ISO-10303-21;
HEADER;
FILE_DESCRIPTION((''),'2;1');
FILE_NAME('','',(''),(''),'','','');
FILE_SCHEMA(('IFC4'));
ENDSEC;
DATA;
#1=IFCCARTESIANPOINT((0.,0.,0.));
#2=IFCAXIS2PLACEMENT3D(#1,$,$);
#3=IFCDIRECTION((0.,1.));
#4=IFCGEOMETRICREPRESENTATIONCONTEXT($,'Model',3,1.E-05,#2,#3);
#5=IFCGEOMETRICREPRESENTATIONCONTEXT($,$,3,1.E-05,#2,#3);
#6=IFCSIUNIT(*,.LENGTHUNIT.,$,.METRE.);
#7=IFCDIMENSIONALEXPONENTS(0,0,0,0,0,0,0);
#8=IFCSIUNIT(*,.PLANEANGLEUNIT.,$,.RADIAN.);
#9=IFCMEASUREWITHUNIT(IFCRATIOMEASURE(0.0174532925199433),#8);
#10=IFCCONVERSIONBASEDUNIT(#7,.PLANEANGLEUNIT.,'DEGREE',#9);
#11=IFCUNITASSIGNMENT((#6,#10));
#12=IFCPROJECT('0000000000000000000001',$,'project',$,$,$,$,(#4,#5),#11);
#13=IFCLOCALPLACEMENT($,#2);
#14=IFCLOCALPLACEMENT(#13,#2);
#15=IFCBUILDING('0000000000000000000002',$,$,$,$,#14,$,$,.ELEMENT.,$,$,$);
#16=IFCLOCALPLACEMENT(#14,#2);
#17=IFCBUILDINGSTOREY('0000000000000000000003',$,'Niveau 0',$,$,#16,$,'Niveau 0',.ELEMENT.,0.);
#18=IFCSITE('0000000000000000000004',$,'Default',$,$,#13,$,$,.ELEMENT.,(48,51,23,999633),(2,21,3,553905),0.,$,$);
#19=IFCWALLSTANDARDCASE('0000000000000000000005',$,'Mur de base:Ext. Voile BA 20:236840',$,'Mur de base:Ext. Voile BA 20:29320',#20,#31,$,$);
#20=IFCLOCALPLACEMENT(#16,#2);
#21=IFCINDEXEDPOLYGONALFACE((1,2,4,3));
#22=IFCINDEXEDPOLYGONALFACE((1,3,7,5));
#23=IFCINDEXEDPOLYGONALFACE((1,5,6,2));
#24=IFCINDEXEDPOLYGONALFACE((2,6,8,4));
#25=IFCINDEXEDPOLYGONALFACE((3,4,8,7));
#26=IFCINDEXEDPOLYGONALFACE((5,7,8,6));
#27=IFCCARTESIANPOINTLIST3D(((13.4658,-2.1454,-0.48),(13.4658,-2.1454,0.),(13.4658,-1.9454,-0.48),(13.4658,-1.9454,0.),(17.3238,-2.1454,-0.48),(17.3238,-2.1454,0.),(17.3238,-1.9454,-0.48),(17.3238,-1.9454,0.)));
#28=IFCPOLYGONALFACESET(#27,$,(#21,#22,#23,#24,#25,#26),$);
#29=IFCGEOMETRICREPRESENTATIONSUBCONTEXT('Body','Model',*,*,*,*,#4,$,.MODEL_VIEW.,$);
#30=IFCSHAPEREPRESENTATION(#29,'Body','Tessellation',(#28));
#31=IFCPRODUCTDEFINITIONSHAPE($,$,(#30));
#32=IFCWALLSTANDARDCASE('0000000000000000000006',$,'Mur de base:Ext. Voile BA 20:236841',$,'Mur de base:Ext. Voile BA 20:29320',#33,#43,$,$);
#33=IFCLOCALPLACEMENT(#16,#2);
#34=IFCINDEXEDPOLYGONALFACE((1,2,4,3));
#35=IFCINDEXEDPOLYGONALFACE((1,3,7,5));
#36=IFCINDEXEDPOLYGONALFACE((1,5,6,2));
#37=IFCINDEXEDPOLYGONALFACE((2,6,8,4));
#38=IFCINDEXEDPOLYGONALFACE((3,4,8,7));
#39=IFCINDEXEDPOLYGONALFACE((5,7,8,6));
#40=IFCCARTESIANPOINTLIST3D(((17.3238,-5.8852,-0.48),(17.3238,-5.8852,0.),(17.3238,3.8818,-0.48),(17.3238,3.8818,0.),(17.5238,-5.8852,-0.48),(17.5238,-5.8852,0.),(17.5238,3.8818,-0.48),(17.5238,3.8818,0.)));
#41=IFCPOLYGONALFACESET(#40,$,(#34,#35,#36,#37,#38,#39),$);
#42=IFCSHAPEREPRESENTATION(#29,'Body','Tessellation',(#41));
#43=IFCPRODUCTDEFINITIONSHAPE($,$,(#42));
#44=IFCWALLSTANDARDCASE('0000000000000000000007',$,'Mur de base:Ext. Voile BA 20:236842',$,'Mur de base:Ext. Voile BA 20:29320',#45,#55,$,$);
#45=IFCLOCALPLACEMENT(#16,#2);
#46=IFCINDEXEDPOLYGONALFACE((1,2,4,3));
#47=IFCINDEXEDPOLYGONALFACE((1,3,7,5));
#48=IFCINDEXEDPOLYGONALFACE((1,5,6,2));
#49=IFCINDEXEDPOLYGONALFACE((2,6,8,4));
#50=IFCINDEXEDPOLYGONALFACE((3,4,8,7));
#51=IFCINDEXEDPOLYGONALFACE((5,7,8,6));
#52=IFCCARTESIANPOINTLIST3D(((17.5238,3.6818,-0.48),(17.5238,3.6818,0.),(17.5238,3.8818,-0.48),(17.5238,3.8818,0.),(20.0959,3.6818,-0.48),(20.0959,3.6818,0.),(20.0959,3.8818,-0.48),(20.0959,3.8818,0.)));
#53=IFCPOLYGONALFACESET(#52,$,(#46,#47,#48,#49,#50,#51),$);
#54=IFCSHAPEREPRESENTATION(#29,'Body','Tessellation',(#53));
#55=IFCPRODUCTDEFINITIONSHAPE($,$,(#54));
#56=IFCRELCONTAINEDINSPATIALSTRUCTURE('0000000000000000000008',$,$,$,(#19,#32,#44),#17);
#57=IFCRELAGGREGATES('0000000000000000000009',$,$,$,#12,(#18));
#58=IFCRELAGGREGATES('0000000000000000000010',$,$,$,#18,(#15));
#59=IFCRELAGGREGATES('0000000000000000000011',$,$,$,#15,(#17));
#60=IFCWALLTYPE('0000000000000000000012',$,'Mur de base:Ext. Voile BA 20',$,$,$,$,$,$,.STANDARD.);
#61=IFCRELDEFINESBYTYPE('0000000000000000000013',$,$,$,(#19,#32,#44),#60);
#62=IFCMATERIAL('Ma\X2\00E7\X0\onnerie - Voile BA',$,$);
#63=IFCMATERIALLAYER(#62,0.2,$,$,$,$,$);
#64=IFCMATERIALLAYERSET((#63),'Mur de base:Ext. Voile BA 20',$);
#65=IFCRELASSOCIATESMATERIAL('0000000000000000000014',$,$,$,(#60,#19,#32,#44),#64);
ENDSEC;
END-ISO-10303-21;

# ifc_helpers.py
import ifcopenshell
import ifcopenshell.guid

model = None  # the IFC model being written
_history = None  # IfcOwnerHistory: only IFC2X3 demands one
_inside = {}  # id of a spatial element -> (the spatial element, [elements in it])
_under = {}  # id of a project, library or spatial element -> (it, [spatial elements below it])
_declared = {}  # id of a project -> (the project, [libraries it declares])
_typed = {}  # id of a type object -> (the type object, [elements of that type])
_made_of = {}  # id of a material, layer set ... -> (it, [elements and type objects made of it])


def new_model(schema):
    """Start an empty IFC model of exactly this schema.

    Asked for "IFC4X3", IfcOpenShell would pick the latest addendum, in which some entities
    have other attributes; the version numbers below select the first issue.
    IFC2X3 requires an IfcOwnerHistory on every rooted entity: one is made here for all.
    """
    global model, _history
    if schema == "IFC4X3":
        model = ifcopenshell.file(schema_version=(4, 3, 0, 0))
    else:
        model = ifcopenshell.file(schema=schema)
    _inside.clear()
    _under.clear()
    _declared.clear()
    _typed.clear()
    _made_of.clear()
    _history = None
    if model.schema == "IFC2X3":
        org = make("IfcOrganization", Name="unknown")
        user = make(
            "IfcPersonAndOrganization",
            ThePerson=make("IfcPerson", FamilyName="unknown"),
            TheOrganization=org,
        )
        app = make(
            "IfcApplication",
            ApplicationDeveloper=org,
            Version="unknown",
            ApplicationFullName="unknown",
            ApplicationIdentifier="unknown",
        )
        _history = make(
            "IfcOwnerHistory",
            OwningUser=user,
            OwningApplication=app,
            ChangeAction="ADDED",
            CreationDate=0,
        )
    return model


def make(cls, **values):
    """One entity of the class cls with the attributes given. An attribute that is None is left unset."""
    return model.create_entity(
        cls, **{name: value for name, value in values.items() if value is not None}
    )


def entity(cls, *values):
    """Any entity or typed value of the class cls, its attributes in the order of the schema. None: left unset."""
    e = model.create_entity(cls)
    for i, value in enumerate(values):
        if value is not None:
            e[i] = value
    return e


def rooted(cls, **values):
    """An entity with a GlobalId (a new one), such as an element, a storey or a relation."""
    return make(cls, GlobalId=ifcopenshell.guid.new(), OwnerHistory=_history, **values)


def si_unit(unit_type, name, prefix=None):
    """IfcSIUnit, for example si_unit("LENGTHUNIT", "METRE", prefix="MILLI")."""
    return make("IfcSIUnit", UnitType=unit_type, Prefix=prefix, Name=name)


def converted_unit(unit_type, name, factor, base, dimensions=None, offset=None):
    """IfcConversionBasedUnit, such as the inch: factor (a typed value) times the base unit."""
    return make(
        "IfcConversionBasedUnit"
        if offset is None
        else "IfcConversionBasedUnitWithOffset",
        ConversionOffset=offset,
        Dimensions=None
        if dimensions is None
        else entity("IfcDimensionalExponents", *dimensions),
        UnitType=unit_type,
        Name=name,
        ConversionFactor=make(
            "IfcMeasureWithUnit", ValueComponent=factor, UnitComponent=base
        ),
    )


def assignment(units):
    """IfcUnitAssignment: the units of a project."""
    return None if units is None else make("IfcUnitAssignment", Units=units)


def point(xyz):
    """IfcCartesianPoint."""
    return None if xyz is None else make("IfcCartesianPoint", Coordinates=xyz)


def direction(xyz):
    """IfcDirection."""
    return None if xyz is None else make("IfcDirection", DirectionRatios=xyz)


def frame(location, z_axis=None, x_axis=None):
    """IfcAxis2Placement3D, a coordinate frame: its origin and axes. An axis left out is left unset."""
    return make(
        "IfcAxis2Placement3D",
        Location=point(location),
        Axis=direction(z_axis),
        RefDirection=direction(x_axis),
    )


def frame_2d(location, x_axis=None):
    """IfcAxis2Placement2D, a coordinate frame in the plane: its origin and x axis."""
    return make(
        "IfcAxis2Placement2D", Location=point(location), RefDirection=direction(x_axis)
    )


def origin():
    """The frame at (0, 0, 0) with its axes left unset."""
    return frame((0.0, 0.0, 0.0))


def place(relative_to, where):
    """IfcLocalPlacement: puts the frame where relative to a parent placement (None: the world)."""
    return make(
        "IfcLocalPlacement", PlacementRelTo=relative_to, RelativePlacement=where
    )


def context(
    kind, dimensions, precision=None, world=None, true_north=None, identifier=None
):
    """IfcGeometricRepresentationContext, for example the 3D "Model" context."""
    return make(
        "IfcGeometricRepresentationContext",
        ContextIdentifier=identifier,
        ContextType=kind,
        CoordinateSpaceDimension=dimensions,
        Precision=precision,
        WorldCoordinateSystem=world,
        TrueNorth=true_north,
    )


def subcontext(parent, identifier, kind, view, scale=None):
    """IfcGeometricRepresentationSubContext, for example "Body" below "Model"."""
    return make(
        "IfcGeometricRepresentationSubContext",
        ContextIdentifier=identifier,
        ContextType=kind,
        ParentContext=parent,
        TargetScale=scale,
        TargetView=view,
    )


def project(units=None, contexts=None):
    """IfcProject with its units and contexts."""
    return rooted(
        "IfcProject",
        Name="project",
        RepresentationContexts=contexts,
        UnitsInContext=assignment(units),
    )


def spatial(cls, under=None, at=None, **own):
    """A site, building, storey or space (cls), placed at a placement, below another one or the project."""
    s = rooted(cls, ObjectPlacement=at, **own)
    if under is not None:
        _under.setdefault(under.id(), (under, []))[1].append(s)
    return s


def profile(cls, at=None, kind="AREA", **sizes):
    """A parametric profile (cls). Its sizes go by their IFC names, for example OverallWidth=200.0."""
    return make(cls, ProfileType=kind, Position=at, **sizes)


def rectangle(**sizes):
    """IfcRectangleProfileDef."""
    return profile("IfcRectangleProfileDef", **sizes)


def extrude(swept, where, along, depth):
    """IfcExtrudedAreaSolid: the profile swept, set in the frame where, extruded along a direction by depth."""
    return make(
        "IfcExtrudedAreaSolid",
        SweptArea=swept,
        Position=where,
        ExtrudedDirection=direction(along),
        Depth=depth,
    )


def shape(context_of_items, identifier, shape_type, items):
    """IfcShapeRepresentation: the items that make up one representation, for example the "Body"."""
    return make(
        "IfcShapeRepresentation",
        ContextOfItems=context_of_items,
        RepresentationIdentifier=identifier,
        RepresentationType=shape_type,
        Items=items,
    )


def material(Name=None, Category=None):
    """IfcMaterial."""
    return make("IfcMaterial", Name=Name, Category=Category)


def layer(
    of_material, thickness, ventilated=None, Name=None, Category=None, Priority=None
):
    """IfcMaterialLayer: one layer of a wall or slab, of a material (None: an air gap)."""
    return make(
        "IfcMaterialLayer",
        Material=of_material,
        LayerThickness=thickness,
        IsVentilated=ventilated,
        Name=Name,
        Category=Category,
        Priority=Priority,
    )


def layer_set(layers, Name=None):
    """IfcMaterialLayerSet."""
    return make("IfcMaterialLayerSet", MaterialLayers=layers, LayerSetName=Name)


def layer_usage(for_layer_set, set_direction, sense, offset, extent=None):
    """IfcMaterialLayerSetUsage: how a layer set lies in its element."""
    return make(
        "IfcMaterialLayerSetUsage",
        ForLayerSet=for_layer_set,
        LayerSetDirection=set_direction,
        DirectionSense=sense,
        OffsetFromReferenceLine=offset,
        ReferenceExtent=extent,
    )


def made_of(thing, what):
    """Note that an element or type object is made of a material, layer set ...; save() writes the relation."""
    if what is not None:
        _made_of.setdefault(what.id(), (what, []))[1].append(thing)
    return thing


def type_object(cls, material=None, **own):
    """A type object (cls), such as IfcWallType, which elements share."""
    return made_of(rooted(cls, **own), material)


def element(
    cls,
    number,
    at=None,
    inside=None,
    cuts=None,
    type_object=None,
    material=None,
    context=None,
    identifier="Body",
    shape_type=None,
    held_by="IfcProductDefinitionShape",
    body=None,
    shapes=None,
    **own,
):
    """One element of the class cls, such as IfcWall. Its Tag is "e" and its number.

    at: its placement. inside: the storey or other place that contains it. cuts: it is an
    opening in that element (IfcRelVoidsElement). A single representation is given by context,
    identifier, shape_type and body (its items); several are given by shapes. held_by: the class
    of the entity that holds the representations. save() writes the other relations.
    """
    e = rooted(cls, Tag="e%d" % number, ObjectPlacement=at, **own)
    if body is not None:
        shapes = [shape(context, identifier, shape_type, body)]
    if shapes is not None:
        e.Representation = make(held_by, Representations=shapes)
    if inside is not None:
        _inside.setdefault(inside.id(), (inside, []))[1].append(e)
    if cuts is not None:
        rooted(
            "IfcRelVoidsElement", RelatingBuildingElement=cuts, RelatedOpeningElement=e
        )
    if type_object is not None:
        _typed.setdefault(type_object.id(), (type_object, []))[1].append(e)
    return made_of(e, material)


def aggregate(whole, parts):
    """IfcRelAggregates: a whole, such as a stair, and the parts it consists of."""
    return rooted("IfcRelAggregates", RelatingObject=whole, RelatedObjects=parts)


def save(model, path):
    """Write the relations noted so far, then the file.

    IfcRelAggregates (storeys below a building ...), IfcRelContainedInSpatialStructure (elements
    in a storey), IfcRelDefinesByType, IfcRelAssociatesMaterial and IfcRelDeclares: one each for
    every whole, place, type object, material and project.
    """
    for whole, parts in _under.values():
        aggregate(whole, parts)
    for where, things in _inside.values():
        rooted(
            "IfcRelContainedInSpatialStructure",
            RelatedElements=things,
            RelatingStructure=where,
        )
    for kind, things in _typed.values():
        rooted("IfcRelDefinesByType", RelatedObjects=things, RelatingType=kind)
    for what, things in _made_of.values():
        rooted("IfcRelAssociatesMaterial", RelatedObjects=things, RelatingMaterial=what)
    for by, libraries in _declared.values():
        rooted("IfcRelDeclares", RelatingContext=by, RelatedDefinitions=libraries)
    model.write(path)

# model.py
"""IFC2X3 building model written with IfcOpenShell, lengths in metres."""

from ifc_helpers import new_model, entity, si_unit, converted_unit, direction, frame, frame_2d, origin, place, context, subcontext, project, spatial, rectangle, extrude, material, layer, layer_set, layer_usage, type_object, element, save


model = new_model("IFC2X3")

# Units and contexts
model_context = context("Model", 3, precision=1e-05, world=origin(), true_north=direction((0.0, 1.0)))
context_of_model = context(None, 3, precision=1e-05, world=origin(), true_north=direction((0.0, 1.0)))
body_context = subcontext(model_context, "Body", "Model", "MODEL_VIEW")
ifc_project = project(units=[si_unit("LENGTHUNIT", "METRE"), converted_unit("PLANEANGLEUNIT", "DEGREE", entity("IfcRatioMeasure", 0.0174532925199433), si_unit("PLANEANGLEUNIT", "RADIAN"), dimensions=[0, 0, 0, 0, 0, 0, 0])], contexts=[model_context, context_of_model])

# Site, building, storey
site_placement = place(None, origin())
site = spatial("IfcSite", under=ifc_project, at=site_placement, Name="Default", CompositionType="ELEMENT", RefLatitude=(48, 51, 23, 999633), RefLongitude=(2, 21, 3, 553905), RefElevation=0.0)
building_placement = place(site_placement, origin())
building = spatial("IfcBuilding", under=site, at=building_placement, CompositionType="ELEMENT")
storey_placement = place(building_placement, origin())
storey = spatial("IfcBuildingStorey", under=building, at=storey_placement, Name="Niveau 0", LongName="Niveau 0", CompositionType="ELEMENT", Elevation=0.0)

# Shared definitions
ifc_material = material(Name="Maçonnerie - Voile BA")
ifc_layer = layer(ifc_material, 0.2)
ifc_layer_set = layer_set([ifc_layer], Name="Mur de base:Ext. Voile BA 20")
wall_type = type_object("IfcWallType", Name="Mur de base:Ext. Voile BA 20", PredefinedType="STANDARD", material=ifc_layer_set)

# Walls
ifc_layer_usage_1 = layer_usage(ifc_layer_set, "AXIS2", "NEGATIVE", 0.1)
wall_1_placement = place(storey_placement, frame((13.4658, -2.0454, -0.48)))
element("IfcWallStandardCase", 1, at=wall_1_placement, inside=storey, type_object=wall_type, material=ifc_layer_usage_1, Name="Mur de base:Ext. Voile BA 20:236840", ObjectType="Mur de base:Ext. Voile BA 20:29320", context=body_context, shape_type="SweptSolid", body=[
    extrude(rectangle(XDim=3.858, YDim=0.2, at=frame_2d((1.929, 0.0), x_axis=(-1.0, 0.0))), origin(), (0.0, 0.0, 1.0), 0.48),
])
ifc_layer_usage_2 = layer_usage(ifc_layer_set, "AXIS2", "NEGATIVE", 0.1)
wall_2_placement = place(storey_placement, frame((17.4238, 3.8818, -0.48), z_axis=(0.0, 0.0, 1.0), x_axis=(0.0, -1.0, 0.0)))
element("IfcWallStandardCase", 2, at=wall_2_placement, inside=storey, type_object=wall_type, material=ifc_layer_usage_2, Name="Mur de base:Ext. Voile BA 20:236841", ObjectType="Mur de base:Ext. Voile BA 20:29320", context=body_context, shape_type="SweptSolid", body=[
    extrude(rectangle(XDim=9.767, YDim=0.2, at=frame_2d((4.8835, 0.0), x_axis=(-1.0, 0.0))), origin(), (0.0, 0.0, 1.0), 0.48),
])
ifc_layer_usage_3 = layer_usage(ifc_layer_set, "AXIS2", "NEGATIVE", 0.1)
wall_3_placement = place(storey_placement, frame((17.5238, 3.7818, -0.48)))
element("IfcWallStandardCase", 3, at=wall_3_placement, inside=storey, type_object=wall_type, material=ifc_layer_usage_3, Name="Mur de base:Ext. Voile BA 20:236842", ObjectType="Mur de base:Ext. Voile BA 20:29320", context=body_context, shape_type="SweptSolid", body=[
    extrude(rectangle(XDim=2.5721, YDim=0.2, at=frame_2d((1.286, 0.0), x_axis=(-1.0, 0.0))), origin(), (0.0, 0.0, 1.0), 0.48),
])

save(model, "model.ifc")
